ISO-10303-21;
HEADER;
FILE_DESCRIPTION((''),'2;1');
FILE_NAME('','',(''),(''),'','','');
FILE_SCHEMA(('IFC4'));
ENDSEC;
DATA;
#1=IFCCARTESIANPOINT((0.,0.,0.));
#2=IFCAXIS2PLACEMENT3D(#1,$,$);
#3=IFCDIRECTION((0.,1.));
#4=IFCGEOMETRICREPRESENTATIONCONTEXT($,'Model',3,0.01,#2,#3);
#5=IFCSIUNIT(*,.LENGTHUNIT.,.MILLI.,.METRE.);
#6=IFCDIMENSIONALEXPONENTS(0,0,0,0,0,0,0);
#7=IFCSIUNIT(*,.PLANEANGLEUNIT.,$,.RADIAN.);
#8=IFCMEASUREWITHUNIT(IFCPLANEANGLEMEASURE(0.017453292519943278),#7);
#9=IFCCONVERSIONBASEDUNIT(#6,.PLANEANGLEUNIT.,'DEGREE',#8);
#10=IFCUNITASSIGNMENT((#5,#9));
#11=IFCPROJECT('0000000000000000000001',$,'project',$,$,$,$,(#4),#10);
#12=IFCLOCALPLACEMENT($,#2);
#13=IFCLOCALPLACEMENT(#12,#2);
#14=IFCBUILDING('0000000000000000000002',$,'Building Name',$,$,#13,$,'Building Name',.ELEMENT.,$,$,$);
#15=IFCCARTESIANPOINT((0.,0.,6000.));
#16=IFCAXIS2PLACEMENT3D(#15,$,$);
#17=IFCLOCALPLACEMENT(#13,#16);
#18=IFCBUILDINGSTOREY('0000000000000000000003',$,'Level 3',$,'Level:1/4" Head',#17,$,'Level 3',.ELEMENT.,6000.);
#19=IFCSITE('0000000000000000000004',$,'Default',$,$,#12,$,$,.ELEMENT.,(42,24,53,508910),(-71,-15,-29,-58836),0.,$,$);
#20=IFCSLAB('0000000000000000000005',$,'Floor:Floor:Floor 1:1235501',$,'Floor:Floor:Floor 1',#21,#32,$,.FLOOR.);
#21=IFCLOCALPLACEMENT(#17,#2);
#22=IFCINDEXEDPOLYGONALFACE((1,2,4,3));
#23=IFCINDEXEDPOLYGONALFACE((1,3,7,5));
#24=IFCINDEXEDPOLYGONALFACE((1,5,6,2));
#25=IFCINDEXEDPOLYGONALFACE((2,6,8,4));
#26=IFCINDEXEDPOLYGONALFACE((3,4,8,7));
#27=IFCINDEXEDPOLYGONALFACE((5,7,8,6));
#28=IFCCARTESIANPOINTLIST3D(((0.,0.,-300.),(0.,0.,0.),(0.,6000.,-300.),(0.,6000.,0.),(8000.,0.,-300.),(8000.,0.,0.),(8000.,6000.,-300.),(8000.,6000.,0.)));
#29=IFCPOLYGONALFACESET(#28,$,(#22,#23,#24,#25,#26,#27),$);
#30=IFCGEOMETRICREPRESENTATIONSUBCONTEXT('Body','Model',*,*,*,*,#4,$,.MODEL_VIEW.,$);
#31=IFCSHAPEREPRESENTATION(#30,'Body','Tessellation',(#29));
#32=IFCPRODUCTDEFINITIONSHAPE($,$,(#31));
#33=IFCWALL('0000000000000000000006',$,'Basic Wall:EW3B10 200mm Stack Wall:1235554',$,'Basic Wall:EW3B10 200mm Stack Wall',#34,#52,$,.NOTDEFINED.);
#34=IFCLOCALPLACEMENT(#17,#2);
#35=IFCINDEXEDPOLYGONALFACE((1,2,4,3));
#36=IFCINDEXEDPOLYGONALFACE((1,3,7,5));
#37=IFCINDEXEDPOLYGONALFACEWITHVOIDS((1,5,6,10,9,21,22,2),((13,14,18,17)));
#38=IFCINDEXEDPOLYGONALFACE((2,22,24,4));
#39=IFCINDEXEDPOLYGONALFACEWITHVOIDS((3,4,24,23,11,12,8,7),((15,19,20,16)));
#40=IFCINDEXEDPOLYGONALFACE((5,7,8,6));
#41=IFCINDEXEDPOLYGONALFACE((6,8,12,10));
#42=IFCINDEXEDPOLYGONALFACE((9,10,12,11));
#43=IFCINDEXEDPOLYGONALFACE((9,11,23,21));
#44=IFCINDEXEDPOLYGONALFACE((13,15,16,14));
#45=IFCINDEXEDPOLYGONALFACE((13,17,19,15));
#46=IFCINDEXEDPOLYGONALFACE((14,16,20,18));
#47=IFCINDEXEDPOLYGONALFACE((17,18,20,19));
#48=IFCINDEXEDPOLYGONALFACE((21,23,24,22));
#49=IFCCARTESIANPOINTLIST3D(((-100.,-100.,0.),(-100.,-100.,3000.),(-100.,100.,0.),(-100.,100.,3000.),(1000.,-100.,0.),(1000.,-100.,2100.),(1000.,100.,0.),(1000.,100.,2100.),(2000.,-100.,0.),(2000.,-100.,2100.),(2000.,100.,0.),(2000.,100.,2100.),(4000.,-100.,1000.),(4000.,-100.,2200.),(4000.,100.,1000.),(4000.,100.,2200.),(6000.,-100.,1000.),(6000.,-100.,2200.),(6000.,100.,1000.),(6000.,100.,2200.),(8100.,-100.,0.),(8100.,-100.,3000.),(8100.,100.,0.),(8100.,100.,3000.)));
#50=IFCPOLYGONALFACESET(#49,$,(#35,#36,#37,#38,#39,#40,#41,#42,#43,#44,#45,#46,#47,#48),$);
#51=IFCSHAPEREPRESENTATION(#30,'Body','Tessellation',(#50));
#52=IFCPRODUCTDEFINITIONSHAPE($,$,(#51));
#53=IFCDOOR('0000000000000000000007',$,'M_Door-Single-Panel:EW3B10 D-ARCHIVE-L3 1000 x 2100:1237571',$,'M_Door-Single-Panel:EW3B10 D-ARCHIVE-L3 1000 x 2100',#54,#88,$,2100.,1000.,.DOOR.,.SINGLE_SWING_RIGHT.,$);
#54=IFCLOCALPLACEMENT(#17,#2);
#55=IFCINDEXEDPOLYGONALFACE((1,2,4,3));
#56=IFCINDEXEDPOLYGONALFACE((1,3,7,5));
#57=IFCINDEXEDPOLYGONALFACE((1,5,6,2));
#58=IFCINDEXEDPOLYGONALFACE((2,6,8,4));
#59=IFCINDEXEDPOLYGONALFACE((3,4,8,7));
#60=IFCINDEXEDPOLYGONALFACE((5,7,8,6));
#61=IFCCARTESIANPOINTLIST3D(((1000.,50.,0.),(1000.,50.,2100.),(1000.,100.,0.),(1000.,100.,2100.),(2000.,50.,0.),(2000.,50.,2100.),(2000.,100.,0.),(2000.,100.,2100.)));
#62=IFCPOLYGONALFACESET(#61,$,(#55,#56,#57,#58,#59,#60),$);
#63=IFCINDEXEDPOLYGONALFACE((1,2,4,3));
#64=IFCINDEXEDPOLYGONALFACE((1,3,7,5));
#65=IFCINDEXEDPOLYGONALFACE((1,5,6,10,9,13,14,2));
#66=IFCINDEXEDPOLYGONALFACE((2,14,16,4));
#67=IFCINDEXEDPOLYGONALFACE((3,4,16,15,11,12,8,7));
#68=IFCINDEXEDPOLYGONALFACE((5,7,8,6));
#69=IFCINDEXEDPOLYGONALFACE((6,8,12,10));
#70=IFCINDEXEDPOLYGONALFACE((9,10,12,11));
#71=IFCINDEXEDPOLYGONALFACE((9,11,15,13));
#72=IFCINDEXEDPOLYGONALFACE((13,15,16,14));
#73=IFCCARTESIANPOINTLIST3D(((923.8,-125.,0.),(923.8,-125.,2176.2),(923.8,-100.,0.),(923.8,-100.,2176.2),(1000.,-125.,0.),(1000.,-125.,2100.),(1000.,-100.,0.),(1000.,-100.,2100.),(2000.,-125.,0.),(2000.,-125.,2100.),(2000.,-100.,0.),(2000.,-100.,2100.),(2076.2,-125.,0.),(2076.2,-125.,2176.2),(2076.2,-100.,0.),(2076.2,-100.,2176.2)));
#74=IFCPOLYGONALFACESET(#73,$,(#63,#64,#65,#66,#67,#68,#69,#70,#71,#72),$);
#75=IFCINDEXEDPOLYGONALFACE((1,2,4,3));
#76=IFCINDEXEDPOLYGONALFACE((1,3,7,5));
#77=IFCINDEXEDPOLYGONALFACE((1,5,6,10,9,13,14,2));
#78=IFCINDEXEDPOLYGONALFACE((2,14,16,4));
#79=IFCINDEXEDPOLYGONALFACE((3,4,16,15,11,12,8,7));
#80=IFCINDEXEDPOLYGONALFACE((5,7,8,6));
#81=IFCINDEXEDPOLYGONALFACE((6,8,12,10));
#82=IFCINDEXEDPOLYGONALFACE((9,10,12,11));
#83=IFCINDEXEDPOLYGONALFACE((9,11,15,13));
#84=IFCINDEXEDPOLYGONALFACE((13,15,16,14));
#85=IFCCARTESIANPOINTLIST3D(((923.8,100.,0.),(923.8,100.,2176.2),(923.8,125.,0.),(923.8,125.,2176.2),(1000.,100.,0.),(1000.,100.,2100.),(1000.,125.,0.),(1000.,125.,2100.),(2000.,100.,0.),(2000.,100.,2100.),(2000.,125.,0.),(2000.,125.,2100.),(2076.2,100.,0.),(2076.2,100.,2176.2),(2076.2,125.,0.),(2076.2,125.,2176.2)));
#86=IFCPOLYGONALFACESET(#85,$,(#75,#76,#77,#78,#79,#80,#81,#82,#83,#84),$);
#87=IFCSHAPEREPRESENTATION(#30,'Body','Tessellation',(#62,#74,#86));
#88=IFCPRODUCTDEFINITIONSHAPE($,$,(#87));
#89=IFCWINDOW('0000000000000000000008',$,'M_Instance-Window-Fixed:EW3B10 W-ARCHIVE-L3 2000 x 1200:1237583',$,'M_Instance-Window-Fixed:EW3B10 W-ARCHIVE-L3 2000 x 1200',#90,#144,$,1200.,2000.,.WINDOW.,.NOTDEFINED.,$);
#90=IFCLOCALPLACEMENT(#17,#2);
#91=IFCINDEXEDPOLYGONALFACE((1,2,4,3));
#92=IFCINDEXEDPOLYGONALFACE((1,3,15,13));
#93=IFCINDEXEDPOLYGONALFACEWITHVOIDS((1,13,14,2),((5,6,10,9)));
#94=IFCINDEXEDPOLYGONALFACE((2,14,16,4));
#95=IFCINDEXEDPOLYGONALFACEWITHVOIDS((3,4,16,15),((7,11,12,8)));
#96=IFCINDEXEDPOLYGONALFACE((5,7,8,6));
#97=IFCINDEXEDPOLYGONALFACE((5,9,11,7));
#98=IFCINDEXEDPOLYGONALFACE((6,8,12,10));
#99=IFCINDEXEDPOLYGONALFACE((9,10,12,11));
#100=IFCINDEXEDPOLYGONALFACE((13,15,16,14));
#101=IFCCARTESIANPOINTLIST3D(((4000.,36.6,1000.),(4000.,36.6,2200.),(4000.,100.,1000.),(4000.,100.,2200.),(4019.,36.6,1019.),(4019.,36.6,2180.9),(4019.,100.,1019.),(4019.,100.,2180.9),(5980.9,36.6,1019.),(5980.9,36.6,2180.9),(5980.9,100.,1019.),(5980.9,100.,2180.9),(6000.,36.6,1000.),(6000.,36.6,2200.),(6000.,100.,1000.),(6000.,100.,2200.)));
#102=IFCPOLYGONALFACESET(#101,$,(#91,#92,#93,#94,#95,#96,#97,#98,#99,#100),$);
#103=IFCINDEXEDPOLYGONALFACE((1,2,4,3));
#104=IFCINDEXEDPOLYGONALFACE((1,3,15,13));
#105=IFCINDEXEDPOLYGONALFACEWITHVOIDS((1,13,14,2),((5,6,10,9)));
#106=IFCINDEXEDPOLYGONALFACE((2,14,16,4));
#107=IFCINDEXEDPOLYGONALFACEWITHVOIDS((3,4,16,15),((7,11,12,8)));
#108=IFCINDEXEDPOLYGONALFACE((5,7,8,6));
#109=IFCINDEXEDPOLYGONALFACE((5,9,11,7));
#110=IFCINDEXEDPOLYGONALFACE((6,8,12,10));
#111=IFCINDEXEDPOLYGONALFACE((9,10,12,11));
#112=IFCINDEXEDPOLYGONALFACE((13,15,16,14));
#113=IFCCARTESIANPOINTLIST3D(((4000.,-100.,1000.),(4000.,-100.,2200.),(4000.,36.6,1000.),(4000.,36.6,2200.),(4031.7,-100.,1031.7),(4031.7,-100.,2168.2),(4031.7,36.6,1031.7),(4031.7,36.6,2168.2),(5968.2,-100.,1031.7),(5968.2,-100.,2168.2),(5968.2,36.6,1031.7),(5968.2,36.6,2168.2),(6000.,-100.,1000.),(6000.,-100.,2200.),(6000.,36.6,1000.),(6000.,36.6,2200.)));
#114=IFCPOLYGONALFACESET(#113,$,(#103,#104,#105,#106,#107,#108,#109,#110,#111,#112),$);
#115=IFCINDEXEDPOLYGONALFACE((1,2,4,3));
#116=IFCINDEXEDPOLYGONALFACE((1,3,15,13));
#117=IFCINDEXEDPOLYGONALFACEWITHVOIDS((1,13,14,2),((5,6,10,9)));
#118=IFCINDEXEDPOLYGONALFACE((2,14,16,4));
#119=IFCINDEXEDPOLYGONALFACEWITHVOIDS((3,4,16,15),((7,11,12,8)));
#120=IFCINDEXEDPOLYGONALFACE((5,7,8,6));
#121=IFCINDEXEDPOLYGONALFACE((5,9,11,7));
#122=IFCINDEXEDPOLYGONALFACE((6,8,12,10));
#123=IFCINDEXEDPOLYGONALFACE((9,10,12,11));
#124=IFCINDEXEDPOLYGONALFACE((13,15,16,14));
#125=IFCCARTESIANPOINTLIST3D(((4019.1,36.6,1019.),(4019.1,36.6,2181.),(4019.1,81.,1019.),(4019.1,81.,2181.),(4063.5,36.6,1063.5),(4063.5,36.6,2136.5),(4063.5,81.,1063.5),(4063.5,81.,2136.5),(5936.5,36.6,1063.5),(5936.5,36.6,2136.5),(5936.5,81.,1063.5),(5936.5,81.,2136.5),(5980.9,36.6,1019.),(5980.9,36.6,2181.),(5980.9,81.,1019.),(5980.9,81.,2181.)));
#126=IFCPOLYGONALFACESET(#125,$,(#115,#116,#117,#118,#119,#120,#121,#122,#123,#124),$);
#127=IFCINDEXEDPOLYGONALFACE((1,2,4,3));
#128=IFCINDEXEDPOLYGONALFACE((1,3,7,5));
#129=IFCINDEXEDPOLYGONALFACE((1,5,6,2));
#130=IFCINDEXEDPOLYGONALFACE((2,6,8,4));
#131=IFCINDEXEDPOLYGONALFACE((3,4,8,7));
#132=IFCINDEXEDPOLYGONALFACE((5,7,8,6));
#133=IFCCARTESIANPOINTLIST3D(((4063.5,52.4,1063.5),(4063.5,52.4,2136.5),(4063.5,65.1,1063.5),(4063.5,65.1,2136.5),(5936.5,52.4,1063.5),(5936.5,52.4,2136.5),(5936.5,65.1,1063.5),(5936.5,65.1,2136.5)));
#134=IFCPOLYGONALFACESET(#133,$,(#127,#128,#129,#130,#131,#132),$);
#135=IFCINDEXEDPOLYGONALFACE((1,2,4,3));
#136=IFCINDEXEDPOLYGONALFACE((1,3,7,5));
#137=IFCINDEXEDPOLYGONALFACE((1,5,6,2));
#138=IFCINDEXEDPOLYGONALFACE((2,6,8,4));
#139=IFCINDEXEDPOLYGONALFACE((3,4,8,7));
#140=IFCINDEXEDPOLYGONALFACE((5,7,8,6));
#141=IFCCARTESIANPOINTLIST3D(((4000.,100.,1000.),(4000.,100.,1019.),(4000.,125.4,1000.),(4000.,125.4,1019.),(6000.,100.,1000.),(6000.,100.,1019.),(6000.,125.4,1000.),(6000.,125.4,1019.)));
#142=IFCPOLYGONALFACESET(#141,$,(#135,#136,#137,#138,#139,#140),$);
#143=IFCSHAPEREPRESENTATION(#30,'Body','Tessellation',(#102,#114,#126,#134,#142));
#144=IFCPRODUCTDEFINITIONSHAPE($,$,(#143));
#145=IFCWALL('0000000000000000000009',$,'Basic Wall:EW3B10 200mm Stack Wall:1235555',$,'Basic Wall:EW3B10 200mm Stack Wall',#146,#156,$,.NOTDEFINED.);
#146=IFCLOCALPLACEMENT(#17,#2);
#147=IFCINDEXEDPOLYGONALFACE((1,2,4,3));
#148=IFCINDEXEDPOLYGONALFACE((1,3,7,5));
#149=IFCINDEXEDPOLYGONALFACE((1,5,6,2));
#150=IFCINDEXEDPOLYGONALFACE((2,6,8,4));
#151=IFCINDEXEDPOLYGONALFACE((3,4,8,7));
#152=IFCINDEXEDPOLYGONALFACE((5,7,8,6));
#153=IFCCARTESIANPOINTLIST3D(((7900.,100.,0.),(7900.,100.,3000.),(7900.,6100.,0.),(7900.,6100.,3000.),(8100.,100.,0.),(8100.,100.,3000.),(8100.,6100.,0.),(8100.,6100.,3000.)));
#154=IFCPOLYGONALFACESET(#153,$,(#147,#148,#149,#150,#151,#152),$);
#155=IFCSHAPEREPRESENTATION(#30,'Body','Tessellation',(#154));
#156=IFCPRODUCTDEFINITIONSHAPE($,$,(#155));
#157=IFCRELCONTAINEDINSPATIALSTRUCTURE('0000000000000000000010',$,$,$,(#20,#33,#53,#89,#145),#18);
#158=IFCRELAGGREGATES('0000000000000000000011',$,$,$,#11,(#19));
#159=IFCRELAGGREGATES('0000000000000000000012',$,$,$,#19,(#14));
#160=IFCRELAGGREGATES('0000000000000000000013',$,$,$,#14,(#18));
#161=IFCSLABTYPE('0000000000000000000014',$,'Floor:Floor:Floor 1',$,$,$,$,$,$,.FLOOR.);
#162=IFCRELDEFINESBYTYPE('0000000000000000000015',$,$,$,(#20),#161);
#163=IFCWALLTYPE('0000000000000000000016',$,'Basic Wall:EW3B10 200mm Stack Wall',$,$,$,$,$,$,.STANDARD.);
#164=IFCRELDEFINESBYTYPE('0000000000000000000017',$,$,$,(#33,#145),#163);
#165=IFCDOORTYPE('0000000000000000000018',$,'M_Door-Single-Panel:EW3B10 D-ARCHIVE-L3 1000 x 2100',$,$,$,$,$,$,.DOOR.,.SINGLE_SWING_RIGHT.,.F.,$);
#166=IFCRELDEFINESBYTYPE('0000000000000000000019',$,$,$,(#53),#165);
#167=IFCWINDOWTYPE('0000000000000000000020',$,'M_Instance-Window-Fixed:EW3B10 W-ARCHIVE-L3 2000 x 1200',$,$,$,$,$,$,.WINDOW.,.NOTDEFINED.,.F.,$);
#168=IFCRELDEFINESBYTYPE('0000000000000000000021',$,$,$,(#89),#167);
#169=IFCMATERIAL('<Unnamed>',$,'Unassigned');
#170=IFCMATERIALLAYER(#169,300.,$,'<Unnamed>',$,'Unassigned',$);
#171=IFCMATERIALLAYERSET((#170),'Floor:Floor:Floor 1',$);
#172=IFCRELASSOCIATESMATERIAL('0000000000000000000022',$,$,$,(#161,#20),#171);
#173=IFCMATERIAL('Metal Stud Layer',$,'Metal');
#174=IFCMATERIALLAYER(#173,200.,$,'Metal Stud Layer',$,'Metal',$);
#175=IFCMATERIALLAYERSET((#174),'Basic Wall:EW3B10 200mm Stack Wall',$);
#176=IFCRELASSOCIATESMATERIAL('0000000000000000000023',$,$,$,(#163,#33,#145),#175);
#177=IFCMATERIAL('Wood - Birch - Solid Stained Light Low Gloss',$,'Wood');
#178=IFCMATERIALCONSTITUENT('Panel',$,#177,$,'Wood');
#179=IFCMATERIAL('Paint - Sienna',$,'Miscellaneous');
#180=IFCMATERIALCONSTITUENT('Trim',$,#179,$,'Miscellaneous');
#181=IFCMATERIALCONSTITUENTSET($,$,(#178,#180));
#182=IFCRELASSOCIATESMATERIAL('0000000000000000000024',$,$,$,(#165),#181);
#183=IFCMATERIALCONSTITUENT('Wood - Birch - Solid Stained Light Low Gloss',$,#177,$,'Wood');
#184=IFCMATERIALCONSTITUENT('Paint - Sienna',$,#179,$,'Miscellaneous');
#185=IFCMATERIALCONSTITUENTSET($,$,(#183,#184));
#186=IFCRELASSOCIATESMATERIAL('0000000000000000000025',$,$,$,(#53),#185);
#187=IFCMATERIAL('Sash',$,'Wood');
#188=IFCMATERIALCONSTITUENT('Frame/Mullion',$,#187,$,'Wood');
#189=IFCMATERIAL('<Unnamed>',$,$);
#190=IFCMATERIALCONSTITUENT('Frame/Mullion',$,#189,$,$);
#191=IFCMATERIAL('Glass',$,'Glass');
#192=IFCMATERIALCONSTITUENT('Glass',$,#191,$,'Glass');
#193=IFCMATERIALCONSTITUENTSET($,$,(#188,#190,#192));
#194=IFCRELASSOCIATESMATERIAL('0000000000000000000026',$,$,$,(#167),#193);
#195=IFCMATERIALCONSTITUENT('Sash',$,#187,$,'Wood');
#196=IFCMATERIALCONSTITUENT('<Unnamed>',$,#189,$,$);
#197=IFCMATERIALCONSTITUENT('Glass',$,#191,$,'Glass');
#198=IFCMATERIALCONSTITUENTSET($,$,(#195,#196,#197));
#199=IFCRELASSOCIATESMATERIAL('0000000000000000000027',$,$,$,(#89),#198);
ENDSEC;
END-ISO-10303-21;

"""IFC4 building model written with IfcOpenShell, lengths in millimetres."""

from ifc_helpers import new_model, entity, si_unit, converted_unit, direction, frame, frame_2d, origin, origin_2d_with_axis, place, context, subcontext, project, spatial, polyline, rectangle, outline, extrude, source, transform, mapped, material, layer, layer_set, layer_usage, constituent, constituent_set, type_object, type_shapes, element, fill, save


model = new_model("IFC4")

# Units and contexts
model_context = context("Model", 3, precision=0.01, world=origin(), true_north=direction((0.0, 1.0)))
body_context = subcontext(model_context, "Body", "Model", "MODEL_VIEW")
ifc_project = project(units=[si_unit("LENGTHUNIT", "METRE", prefix="MILLI"), converted_unit("PLANEANGLEUNIT", "DEGREE", entity("IfcPlaneAngleMeasure", 0.017453292519943278), si_unit("PLANEANGLEUNIT", "RADIAN"), dimensions=[0, 0, 0, 0, 0, 0, 0])], contexts=[model_context])

# Site, building, storey
site_placement = place(None, origin())
site = spatial("IfcSite", under=ifc_project, at=site_placement, Name="Default", CompositionType="ELEMENT", RefLatitude=(42, 24, 53, 508910), RefLongitude=(-71, -15, -29, -58836), RefElevation=0.0)
building_placement = place(site_placement, origin())
building = spatial("IfcBuilding", under=site, at=building_placement, Name="Building Name", LongName="Building Name", CompositionType="ELEMENT")
storey_placement = place(building_placement, frame((0.0, 0.0, 6000.0)))
storey = spatial("IfcBuildingStorey", under=building, at=storey_placement, Name="Level 3", ObjectType="Level:1/4\" Head", LongName="Level 3", CompositionType="ELEMENT", Elevation=6000.0)

# Slab
ifc_material_1 = material(Name="<Unnamed>", Category="Unassigned")
ifc_layer_1 = layer(ifc_material_1, 300.0, Name="<Unnamed>", Category="Unassigned")
ifc_layer_set_1 = layer_set([ifc_layer_1], Name="Floor:Floor:Floor 1")
ifc_layer_usage_1 = layer_usage(ifc_layer_set_1, "AXIS3", "POSITIVE", 0.0)
slab_type = type_object("IfcSlabType", Name="Floor:Floor:Floor 1", PredefinedType="FLOOR", material=ifc_layer_set_1)
slab_placement = place(storey_placement, origin())
element("IfcSlab", 1, at=slab_placement, inside=storey, type_object=slab_type, material=ifc_layer_usage_1, Name="Floor:Floor:Floor 1:1235501", ObjectType="Floor:Floor:Floor 1", PredefinedType="FLOOR", context=body_context, shape_type="SweptSolid", body=[
    extrude(rectangle(XDim=6000.0, YDim=8000.0, at=origin_2d_with_axis()), frame((4000.0, 3000.0, 0.0), z_axis=(0.0, 0.0, -1.0), x_axis=(0.0, 1.0, 0.0)), (0.0, 0.0, 1.0), 300.0),
])

# Wall, openings, door, window
ifc_material_2 = material(Name="Metal Stud Layer", Category="Metal")
ifc_layer_2 = layer(ifc_material_2, 200.0, Name="Metal Stud Layer", Category="Metal")
ifc_layer_set_2 = layer_set([ifc_layer_2], Name="Basic Wall:EW3B10 200mm Stack Wall")
ifc_layer_usage_2 = layer_usage(ifc_layer_set_2, "AXIS2", "NEGATIVE", 100.0)
wall_type = type_object("IfcWallType", Name="Basic Wall:EW3B10 200mm Stack Wall", PredefinedType="STANDARD", material=ifc_layer_set_2)
wall_1_placement = place(storey_placement, frame((-100.0, 0.0, 0.0)))
wall_1 = element("IfcWall", 2, at=wall_1_placement, inside=storey, type_object=wall_type, material=ifc_layer_usage_2, Name="Basic Wall:EW3B10 200mm Stack Wall:1235554", ObjectType="Basic Wall:EW3B10 200mm Stack Wall", PredefinedType="NOTDEFINED", context=body_context, shape_type="SweptSolid", body=[
    extrude(rectangle(XDim=8200.0, YDim=200.0, at=frame_2d((4100.0, 0.0), x_axis=(1.0, 0.0))), origin(), (0.0, 0.0, 1.0), 3000.0),
])
opening_1_placement = place(wall_1_placement, frame((1100.0, -100.0, 0.0)))
opening_1 = element("IfcOpeningElement", 3, at=opening_1_placement, cuts=wall_1, PredefinedType="OPENING", context=body_context, shape_type="SweptSolid", body=[
    extrude(rectangle(XDim=1000.0, YDim=2100.0, at=frame_2d((1050.0, 500.0), x_axis=(0.0, 1.0))), frame((0.0, 0.0, 0.0), z_axis=(0.0, 1.0, 0.0), x_axis=(0.0, 0.0, 1.0)), (0.0, 0.0, 1.0), 200.0),
])
opening_2_placement = place(wall_1_placement, frame((4100.0, -100.0, 1000.0)))
opening_2 = element("IfcOpeningElement", 4, at=opening_2_placement, cuts=wall_1, PredefinedType="OPENING", context=body_context, shape_type="SweptSolid", body=[
    extrude(rectangle(XDim=1200.0, YDim=2000.0, at=frame_2d((600.0, 1000.0), x_axis=(-1.0, 0.0))), frame((0.0, 0.0, 0.0), z_axis=(0.0, 1.0, 0.0), x_axis=(0.0, 0.0, 1.0)), (0.0, 0.0, 1.0), 200.0),
])
ifc_material_3 = material(Name="Wood - Birch - Solid Stained Light Low Gloss", Category="Wood")
ifc_constituent_1 = constituent(ifc_material_3, Name="Wood - Birch - Solid Stained Light Low Gloss", Category="Wood")
ifc_material_4 = material(Name="Paint - Sienna", Category="Miscellaneous")
ifc_constituent_2 = constituent(ifc_material_4, Name="Paint - Sienna", Category="Miscellaneous")
ifc_constituent_set_1 = constituent_set(constituents=[ifc_constituent_1, ifc_constituent_2])
ifc_constituent_3 = constituent(ifc_material_3, Name="Panel", Category="Wood")
ifc_constituent_4 = constituent(ifc_material_4, Name="Trim", Category="Miscellaneous")
ifc_constituent_set_2 = constituent_set(constituents=[ifc_constituent_3, ifc_constituent_4])
door_type = type_object("IfcDoorType", Name="M_Door-Single-Panel:EW3B10 D-ARCHIVE-L3 1000 x 2100", OperationType="SINGLE_SWING_RIGHT", ParameterTakesPrecedence=False, PredefinedType="DOOR", material=ifc_constituent_set_2)
shared_shape_1 = source(origin(), body_context, "Body", "SweptSolid", [
    extrude(rectangle(XDim=50.0, YDim=1000.0, at=frame_2d((0.0, 0.0), x_axis=(1.0, 0.0))), frame((500.0, 175.0, 0.0), z_axis=(0.0, 0.0, 1.0), x_axis=(0.0, 1.0, 0.0)), (0.0, 0.0, 1.0), 2100.0),
    extrude(outline(polyline([(-1107.1, -576.2), (1069.0, -576.2), (1069.0, -500.0), (-1030.9, -500.0), (-1030.9, 500.0), (1069.0, 500.0), (1069.0, 576.2), (-1107.1, 576.2), (-1107.1, -576.2)])), frame((500.0, -25.0, 1069.0), z_axis=(0.0, 1.0, 0.0), x_axis=(0.0, 0.0, -1.0)), (0.0, 0.0, 1.0), 25.0),
    extrude(outline(polyline([(-576.2, -1107.1), (576.2, -1107.1), (576.2, 1069.1), (500.0, 1069.1), (500.0, -1031.0), (-500.0, -1031.0), (-500.0, 1069.1), (-576.2, 1069.1), (-576.2, -1107.1)])), frame((500.0, 200.0, 1069.1), z_axis=(0.0, 1.0, 0.0), x_axis=(1.0, 0.0, 0.0)), (0.0, 0.0, 1.0), 25.0),
])
type_shapes(door_type, [shared_shape_1])
door_placement = place(opening_1_placement, origin())
door = element("IfcDoor", 5, at=door_placement, inside=storey, type_object=door_type, material=ifc_constituent_set_1, Name="M_Door-Single-Panel:EW3B10 D-ARCHIVE-L3 1000 x 2100:1237571", ObjectType="M_Door-Single-Panel:EW3B10 D-ARCHIVE-L3 1000 x 2100", OperationType="SINGLE_SWING_RIGHT", OverallHeight=2100.0, OverallWidth=1000.0, PredefinedType="DOOR", context=body_context, shape_type="MappedRepresentation", body=[
    mapped(shared_shape_1, transform((0.0, 0.0, 0.0), scale=1.0)),
])
fill(opening_1, door)
ifc_material_5 = material(Name="Sash", Category="Wood")
ifc_constituent_5 = constituent(ifc_material_5, Name="Sash", Category="Wood")
ifc_material_6 = material(Name="<Unnamed>")
ifc_constituent_6 = constituent(ifc_material_6, Name="<Unnamed>")
ifc_material_7 = material(Name="Glass", Category="Glass")
ifc_constituent_7 = constituent(ifc_material_7, Name="Glass", Category="Glass")
ifc_constituent_set_3 = constituent_set(constituents=[ifc_constituent_5, ifc_constituent_6, ifc_constituent_7])
ifc_constituent_8 = constituent(ifc_material_5, Name="Frame/Mullion", Category="Wood")
ifc_constituent_9 = constituent(ifc_material_6, Name="Frame/Mullion")
ifc_constituent_10 = constituent(ifc_material_7, Name="Glass", Category="Glass")
ifc_constituent_set_4 = constituent_set(constituents=[ifc_constituent_8, ifc_constituent_9, ifc_constituent_10])
window_type = type_object("IfcWindowType", Name="M_Instance-Window-Fixed:EW3B10 W-ARCHIVE-L3 2000 x 1200", ParameterTakesPrecedence=False, PartitioningType="NOTDEFINED", PredefinedType="WINDOW", material=ifc_constituent_set_4)
shared_shape_2 = source(origin(), body_context, "Body", "SweptSolid", [
    extrude(outline(polyline([(-600.0, -1000.0), (600.0, -1000.0), (600.0, 1000.0), (-600.0, 1000.0), (-600.0, -1000.0)]), holes=[polyline([(-580.9, -980.9), (-580.9, 981.0), (581.0, 981.0), (581.0, -980.9), (-580.9, -980.9)])]), frame((1000.0, 136.6, 600.0), z_axis=(0.0, 1.0, 0.0), x_axis=(0.0, 0.0, -1.0)), (0.0, 0.0, 1.0), 63.5),
    extrude(outline(polyline([(-1000.0, -600.0), (1000.0, -600.0), (1000.0, 600.0), (-1000.0, 600.0), (-1000.0, -600.0)]), holes=[polyline([(-968.3, -568.2), (-968.3, 568.3), (968.2, 568.3), (968.2, -568.2), (-968.3, -568.2)])]), frame((1000.0, 0.0, 600.0), z_axis=(0.0, 1.0, 0.0), x_axis=(1.0, 0.0, 0.0)), (0.0, 0.0, 1.0), 136.6),
    extrude(outline(polyline([(-980.9, -581.0), (980.9, -581.0), (980.9, 581.0), (-980.9, 581.0), (-980.9, -581.0)]), holes=[polyline([(-936.5, -536.5), (-936.5, 536.5), (936.5, 536.5), (936.5, -536.5), (-936.5, -536.5)])]), frame((1000.0, 136.6, 600.0), z_axis=(0.0, 1.0, 0.0), x_axis=(1.0, 0.0, 0.0)), (0.0, 0.0, 1.0), 44.4),
    extrude(rectangle(XDim=12.7, YDim=1873.0, at=frame_2d((0.0, 0.0), x_axis=(1.0, 0.0))), frame((1000.0, 158.8, 63.5), z_axis=(0.0, 0.0, 1.0), x_axis=(0.0, 1.0, 0.0)), (0.0, 0.0, 1.0), 1073.0),
    extrude(rectangle(XDim=25.4, YDim=2000.0, at=frame_2d((0.0, 0.0), x_axis=(1.0, 0.0))), frame((1000.0, 212.7, 0.0), z_axis=(0.0, 0.0, 1.0), x_axis=(0.0, -1.0, 0.0)), (0.0, 0.0, 1.0), 19.0),
])
type_shapes(window_type, [shared_shape_2])
window_placement = place(opening_2_placement, origin())
window = element("IfcWindow", 6, at=window_placement, inside=storey, type_object=window_type, material=ifc_constituent_set_3, Name="M_Instance-Window-Fixed:EW3B10 W-ARCHIVE-L3 2000 x 1200:1237583", ObjectType="M_Instance-Window-Fixed:EW3B10 W-ARCHIVE-L3 2000 x 1200", OverallHeight=1200.0, OverallWidth=2000.0, PartitioningType="NOTDEFINED", PredefinedType="WINDOW", context=body_context, shape_type="MappedRepresentation", body=[
    mapped(shared_shape_2, transform((0.0, 0.0, 0.0), scale=1.0)),
])
fill(opening_2, window)

# Wall
ifc_layer_usage_3 = layer_usage(ifc_layer_set_2, "AXIS2", "NEGATIVE", 100.0)
wall_2_placement = place(storey_placement, frame((8000.0, 100.0, 0.0), z_axis=(0.0, 0.0, 1.0), x_axis=(0.0, 1.0, 0.0)))
element("IfcWall", 7, at=wall_2_placement, inside=storey, type_object=wall_type, material=ifc_layer_usage_3, Name="Basic Wall:EW3B10 200mm Stack Wall:1235555", ObjectType="Basic Wall:EW3B10 200mm Stack Wall", PredefinedType="NOTDEFINED", context=body_context, shape_type="SweptSolid", body=[
    extrude(rectangle(XDim=6000.0, YDim=200.0, at=frame_2d((3000.0, 0.0), x_axis=(-1.0, 0.0))), origin(), (0.0, 0.0, 1.0), 3000.0),
])

save(model, "model.ifc")
